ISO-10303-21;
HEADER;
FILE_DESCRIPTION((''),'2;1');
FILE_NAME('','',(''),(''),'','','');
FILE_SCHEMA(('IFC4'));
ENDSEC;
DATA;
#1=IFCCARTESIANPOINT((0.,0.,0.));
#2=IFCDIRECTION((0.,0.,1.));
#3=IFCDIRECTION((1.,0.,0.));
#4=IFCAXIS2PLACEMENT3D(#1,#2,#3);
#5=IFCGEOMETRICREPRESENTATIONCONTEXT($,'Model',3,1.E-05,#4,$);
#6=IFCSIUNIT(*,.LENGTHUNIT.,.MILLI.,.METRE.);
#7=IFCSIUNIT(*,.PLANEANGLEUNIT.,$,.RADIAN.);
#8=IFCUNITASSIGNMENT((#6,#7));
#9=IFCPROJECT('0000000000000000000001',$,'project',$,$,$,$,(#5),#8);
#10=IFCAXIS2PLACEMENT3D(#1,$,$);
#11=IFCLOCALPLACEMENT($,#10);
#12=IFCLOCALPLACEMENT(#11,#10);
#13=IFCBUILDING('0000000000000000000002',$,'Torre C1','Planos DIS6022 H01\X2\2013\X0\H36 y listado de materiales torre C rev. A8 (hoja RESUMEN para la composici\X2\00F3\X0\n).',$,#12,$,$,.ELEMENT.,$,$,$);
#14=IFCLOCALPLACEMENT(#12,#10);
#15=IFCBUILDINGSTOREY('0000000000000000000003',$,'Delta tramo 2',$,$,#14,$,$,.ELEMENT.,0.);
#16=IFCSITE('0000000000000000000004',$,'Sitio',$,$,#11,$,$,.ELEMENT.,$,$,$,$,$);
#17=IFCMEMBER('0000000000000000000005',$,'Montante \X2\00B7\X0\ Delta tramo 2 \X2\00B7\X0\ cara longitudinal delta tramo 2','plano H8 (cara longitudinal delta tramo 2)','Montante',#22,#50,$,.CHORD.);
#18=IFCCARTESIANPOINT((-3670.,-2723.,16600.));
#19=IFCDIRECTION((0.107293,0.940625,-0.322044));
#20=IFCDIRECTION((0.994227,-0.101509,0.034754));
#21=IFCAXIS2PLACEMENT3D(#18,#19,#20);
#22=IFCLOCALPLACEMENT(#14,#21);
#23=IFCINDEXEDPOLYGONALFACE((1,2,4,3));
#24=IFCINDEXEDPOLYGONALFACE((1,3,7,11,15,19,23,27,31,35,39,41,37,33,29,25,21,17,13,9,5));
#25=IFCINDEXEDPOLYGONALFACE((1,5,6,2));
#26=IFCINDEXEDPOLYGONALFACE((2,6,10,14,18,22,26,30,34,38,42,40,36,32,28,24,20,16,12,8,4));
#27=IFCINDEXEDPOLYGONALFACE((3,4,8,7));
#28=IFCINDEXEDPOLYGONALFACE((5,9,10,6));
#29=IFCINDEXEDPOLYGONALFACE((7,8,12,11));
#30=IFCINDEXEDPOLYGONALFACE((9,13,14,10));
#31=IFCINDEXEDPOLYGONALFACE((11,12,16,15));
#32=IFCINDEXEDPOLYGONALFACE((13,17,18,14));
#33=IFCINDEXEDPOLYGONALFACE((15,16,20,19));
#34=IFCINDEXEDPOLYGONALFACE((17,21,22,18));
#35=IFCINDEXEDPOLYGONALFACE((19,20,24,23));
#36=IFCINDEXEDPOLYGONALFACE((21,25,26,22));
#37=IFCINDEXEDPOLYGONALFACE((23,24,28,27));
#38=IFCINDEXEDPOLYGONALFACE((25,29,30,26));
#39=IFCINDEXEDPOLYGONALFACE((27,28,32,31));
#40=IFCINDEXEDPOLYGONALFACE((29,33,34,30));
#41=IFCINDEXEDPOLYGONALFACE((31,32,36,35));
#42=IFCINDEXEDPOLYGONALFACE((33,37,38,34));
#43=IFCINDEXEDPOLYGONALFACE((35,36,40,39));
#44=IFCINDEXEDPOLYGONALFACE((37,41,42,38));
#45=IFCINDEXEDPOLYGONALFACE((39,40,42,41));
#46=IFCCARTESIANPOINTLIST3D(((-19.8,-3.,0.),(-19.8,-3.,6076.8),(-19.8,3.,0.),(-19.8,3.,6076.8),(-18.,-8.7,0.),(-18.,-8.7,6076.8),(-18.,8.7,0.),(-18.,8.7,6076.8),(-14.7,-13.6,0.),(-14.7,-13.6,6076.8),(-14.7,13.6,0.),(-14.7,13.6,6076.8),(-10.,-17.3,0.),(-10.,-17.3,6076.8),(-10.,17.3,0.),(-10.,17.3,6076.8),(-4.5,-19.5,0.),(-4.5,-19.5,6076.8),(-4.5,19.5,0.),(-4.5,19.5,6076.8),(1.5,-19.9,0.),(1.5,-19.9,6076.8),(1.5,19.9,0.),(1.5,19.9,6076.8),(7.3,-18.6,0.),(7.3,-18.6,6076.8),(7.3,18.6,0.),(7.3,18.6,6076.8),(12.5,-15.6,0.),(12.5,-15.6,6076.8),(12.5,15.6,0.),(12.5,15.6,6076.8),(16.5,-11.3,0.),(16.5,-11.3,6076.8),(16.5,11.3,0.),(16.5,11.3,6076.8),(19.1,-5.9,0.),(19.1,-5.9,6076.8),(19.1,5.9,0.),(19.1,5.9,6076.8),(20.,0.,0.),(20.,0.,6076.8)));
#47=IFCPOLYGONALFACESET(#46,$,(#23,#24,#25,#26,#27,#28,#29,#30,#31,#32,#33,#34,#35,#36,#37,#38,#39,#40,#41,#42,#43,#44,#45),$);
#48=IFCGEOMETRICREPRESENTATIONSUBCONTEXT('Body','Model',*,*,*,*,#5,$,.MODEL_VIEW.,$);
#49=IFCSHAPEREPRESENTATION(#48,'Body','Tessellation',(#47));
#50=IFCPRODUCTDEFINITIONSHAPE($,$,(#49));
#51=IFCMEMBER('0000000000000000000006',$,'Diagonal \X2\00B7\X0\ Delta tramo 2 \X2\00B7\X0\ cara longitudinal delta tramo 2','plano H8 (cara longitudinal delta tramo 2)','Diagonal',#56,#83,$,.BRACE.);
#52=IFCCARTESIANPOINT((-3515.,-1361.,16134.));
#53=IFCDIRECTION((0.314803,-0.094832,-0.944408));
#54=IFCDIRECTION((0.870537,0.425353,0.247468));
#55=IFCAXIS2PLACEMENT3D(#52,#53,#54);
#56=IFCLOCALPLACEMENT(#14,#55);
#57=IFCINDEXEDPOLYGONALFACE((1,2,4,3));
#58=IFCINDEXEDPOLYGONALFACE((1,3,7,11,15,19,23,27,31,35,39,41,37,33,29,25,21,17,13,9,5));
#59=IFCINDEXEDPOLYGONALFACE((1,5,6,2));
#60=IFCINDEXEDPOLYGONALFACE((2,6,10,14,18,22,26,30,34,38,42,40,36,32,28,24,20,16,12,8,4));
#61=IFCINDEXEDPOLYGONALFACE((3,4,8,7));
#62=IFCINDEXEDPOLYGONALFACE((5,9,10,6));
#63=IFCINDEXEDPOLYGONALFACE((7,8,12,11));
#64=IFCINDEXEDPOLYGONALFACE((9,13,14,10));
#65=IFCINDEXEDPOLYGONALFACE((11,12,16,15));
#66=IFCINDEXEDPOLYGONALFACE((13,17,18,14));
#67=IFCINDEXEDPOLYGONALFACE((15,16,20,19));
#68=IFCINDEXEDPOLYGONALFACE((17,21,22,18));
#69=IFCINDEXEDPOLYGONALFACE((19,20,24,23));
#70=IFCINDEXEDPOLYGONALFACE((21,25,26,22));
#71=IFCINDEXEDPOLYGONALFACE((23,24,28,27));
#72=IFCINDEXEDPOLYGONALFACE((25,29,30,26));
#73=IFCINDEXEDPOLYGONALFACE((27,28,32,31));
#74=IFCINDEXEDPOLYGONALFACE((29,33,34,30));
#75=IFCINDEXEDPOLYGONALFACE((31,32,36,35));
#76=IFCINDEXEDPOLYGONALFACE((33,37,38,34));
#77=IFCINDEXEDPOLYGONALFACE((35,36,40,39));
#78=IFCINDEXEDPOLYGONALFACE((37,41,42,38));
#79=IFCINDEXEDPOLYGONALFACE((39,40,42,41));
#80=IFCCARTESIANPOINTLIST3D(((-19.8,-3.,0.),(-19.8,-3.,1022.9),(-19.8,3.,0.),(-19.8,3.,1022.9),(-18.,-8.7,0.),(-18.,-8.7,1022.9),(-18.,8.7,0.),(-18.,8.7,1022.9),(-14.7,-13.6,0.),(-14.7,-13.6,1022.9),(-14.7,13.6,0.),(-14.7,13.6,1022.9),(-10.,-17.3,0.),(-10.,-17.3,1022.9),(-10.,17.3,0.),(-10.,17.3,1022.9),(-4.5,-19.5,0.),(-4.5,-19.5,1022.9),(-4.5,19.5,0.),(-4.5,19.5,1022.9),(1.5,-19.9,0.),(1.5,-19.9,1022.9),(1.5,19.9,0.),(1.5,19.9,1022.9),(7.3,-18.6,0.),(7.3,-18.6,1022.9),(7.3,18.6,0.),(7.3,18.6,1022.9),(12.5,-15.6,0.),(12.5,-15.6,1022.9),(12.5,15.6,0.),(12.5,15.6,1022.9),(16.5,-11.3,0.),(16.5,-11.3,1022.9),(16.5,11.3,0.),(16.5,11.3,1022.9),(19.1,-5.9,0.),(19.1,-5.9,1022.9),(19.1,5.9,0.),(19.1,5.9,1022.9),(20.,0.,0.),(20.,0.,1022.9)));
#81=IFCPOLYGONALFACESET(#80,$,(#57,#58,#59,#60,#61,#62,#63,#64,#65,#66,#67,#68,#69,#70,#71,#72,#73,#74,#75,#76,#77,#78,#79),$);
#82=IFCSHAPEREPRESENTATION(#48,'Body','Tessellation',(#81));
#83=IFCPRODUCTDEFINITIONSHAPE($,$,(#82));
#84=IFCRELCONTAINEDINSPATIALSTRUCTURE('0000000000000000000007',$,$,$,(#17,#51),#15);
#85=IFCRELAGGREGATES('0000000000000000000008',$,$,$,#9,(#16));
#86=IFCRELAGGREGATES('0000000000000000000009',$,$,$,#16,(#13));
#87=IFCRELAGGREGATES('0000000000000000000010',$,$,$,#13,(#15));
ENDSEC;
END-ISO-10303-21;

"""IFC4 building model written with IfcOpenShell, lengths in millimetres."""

from ifc_helpers import new_model, si_unit, frame, origin, origin_with_axes, place, context, subcontext, project, spatial, circle, extrude, element, save


model = new_model("IFC4")

# Units and contexts
model_context = context("Model", 3, precision=1e-05, world=origin_with_axes())
body_context = subcontext(model_context, "Body", "Model", "MODEL_VIEW")
ifc_project = project(units=[si_unit("LENGTHUNIT", "METRE", prefix="MILLI"), si_unit("PLANEANGLEUNIT", "RADIAN")], contexts=[model_context])

# Site, building, storey
site_placement = place(None, origin())
site = spatial("IfcSite", under=ifc_project, at=site_placement, Name="Sitio", CompositionType="ELEMENT")
building_placement = place(site_placement, origin())
building = spatial("IfcBuilding", under=site, at=building_placement, Name="Torre C1", Description="Planos DIS6022 H01–H36 y listado de materiales torre C rev. A8 (hoja RESUMEN para la composición).", CompositionType="ELEMENT")
storey_placement = place(building_placement, origin())
storey = spatial("IfcBuildingStorey", under=building, at=storey_placement, Name="Delta tramo 2", CompositionType="ELEMENT", Elevation=0.0)

# Members
member_1_placement = place(storey_placement, frame((-3670.0, -2723.0, 16600.0), z_axis=(0.107293, 0.940625, -0.322044), x_axis=(0.994227, -0.101509, 0.034754)))
element("IfcMember", 1, at=member_1_placement, inside=storey, Name="Montante · Delta tramo 2 · cara longitudinal delta tramo 2", Description="plano H8 (cara longitudinal delta tramo 2)", ObjectType="Montante", PredefinedType="CHORD", context=body_context, shape_type="SweptSolid", body=[
    extrude(circle(Radius=20.0), None, (0.0, 0.0, 1.0), 6076.8),
])
member_2_placement = place(storey_placement, frame((-3515.0, -1361.0, 16134.0), z_axis=(0.314803, -0.094832, -0.944408), x_axis=(0.870537, 0.425353, 0.247468)))
element("IfcMember", 2, at=member_2_placement, inside=storey, Name="Diagonal · Delta tramo 2 · cara longitudinal delta tramo 2", Description="plano H8 (cara longitudinal delta tramo 2)", ObjectType="Diagonal", PredefinedType="BRACE", context=body_context, shape_type="SweptSolid", body=[
    extrude(circle(Radius=20.0), None, (0.0, 0.0, 1.0), 1022.9),
])

save(model, "model.ifc")
